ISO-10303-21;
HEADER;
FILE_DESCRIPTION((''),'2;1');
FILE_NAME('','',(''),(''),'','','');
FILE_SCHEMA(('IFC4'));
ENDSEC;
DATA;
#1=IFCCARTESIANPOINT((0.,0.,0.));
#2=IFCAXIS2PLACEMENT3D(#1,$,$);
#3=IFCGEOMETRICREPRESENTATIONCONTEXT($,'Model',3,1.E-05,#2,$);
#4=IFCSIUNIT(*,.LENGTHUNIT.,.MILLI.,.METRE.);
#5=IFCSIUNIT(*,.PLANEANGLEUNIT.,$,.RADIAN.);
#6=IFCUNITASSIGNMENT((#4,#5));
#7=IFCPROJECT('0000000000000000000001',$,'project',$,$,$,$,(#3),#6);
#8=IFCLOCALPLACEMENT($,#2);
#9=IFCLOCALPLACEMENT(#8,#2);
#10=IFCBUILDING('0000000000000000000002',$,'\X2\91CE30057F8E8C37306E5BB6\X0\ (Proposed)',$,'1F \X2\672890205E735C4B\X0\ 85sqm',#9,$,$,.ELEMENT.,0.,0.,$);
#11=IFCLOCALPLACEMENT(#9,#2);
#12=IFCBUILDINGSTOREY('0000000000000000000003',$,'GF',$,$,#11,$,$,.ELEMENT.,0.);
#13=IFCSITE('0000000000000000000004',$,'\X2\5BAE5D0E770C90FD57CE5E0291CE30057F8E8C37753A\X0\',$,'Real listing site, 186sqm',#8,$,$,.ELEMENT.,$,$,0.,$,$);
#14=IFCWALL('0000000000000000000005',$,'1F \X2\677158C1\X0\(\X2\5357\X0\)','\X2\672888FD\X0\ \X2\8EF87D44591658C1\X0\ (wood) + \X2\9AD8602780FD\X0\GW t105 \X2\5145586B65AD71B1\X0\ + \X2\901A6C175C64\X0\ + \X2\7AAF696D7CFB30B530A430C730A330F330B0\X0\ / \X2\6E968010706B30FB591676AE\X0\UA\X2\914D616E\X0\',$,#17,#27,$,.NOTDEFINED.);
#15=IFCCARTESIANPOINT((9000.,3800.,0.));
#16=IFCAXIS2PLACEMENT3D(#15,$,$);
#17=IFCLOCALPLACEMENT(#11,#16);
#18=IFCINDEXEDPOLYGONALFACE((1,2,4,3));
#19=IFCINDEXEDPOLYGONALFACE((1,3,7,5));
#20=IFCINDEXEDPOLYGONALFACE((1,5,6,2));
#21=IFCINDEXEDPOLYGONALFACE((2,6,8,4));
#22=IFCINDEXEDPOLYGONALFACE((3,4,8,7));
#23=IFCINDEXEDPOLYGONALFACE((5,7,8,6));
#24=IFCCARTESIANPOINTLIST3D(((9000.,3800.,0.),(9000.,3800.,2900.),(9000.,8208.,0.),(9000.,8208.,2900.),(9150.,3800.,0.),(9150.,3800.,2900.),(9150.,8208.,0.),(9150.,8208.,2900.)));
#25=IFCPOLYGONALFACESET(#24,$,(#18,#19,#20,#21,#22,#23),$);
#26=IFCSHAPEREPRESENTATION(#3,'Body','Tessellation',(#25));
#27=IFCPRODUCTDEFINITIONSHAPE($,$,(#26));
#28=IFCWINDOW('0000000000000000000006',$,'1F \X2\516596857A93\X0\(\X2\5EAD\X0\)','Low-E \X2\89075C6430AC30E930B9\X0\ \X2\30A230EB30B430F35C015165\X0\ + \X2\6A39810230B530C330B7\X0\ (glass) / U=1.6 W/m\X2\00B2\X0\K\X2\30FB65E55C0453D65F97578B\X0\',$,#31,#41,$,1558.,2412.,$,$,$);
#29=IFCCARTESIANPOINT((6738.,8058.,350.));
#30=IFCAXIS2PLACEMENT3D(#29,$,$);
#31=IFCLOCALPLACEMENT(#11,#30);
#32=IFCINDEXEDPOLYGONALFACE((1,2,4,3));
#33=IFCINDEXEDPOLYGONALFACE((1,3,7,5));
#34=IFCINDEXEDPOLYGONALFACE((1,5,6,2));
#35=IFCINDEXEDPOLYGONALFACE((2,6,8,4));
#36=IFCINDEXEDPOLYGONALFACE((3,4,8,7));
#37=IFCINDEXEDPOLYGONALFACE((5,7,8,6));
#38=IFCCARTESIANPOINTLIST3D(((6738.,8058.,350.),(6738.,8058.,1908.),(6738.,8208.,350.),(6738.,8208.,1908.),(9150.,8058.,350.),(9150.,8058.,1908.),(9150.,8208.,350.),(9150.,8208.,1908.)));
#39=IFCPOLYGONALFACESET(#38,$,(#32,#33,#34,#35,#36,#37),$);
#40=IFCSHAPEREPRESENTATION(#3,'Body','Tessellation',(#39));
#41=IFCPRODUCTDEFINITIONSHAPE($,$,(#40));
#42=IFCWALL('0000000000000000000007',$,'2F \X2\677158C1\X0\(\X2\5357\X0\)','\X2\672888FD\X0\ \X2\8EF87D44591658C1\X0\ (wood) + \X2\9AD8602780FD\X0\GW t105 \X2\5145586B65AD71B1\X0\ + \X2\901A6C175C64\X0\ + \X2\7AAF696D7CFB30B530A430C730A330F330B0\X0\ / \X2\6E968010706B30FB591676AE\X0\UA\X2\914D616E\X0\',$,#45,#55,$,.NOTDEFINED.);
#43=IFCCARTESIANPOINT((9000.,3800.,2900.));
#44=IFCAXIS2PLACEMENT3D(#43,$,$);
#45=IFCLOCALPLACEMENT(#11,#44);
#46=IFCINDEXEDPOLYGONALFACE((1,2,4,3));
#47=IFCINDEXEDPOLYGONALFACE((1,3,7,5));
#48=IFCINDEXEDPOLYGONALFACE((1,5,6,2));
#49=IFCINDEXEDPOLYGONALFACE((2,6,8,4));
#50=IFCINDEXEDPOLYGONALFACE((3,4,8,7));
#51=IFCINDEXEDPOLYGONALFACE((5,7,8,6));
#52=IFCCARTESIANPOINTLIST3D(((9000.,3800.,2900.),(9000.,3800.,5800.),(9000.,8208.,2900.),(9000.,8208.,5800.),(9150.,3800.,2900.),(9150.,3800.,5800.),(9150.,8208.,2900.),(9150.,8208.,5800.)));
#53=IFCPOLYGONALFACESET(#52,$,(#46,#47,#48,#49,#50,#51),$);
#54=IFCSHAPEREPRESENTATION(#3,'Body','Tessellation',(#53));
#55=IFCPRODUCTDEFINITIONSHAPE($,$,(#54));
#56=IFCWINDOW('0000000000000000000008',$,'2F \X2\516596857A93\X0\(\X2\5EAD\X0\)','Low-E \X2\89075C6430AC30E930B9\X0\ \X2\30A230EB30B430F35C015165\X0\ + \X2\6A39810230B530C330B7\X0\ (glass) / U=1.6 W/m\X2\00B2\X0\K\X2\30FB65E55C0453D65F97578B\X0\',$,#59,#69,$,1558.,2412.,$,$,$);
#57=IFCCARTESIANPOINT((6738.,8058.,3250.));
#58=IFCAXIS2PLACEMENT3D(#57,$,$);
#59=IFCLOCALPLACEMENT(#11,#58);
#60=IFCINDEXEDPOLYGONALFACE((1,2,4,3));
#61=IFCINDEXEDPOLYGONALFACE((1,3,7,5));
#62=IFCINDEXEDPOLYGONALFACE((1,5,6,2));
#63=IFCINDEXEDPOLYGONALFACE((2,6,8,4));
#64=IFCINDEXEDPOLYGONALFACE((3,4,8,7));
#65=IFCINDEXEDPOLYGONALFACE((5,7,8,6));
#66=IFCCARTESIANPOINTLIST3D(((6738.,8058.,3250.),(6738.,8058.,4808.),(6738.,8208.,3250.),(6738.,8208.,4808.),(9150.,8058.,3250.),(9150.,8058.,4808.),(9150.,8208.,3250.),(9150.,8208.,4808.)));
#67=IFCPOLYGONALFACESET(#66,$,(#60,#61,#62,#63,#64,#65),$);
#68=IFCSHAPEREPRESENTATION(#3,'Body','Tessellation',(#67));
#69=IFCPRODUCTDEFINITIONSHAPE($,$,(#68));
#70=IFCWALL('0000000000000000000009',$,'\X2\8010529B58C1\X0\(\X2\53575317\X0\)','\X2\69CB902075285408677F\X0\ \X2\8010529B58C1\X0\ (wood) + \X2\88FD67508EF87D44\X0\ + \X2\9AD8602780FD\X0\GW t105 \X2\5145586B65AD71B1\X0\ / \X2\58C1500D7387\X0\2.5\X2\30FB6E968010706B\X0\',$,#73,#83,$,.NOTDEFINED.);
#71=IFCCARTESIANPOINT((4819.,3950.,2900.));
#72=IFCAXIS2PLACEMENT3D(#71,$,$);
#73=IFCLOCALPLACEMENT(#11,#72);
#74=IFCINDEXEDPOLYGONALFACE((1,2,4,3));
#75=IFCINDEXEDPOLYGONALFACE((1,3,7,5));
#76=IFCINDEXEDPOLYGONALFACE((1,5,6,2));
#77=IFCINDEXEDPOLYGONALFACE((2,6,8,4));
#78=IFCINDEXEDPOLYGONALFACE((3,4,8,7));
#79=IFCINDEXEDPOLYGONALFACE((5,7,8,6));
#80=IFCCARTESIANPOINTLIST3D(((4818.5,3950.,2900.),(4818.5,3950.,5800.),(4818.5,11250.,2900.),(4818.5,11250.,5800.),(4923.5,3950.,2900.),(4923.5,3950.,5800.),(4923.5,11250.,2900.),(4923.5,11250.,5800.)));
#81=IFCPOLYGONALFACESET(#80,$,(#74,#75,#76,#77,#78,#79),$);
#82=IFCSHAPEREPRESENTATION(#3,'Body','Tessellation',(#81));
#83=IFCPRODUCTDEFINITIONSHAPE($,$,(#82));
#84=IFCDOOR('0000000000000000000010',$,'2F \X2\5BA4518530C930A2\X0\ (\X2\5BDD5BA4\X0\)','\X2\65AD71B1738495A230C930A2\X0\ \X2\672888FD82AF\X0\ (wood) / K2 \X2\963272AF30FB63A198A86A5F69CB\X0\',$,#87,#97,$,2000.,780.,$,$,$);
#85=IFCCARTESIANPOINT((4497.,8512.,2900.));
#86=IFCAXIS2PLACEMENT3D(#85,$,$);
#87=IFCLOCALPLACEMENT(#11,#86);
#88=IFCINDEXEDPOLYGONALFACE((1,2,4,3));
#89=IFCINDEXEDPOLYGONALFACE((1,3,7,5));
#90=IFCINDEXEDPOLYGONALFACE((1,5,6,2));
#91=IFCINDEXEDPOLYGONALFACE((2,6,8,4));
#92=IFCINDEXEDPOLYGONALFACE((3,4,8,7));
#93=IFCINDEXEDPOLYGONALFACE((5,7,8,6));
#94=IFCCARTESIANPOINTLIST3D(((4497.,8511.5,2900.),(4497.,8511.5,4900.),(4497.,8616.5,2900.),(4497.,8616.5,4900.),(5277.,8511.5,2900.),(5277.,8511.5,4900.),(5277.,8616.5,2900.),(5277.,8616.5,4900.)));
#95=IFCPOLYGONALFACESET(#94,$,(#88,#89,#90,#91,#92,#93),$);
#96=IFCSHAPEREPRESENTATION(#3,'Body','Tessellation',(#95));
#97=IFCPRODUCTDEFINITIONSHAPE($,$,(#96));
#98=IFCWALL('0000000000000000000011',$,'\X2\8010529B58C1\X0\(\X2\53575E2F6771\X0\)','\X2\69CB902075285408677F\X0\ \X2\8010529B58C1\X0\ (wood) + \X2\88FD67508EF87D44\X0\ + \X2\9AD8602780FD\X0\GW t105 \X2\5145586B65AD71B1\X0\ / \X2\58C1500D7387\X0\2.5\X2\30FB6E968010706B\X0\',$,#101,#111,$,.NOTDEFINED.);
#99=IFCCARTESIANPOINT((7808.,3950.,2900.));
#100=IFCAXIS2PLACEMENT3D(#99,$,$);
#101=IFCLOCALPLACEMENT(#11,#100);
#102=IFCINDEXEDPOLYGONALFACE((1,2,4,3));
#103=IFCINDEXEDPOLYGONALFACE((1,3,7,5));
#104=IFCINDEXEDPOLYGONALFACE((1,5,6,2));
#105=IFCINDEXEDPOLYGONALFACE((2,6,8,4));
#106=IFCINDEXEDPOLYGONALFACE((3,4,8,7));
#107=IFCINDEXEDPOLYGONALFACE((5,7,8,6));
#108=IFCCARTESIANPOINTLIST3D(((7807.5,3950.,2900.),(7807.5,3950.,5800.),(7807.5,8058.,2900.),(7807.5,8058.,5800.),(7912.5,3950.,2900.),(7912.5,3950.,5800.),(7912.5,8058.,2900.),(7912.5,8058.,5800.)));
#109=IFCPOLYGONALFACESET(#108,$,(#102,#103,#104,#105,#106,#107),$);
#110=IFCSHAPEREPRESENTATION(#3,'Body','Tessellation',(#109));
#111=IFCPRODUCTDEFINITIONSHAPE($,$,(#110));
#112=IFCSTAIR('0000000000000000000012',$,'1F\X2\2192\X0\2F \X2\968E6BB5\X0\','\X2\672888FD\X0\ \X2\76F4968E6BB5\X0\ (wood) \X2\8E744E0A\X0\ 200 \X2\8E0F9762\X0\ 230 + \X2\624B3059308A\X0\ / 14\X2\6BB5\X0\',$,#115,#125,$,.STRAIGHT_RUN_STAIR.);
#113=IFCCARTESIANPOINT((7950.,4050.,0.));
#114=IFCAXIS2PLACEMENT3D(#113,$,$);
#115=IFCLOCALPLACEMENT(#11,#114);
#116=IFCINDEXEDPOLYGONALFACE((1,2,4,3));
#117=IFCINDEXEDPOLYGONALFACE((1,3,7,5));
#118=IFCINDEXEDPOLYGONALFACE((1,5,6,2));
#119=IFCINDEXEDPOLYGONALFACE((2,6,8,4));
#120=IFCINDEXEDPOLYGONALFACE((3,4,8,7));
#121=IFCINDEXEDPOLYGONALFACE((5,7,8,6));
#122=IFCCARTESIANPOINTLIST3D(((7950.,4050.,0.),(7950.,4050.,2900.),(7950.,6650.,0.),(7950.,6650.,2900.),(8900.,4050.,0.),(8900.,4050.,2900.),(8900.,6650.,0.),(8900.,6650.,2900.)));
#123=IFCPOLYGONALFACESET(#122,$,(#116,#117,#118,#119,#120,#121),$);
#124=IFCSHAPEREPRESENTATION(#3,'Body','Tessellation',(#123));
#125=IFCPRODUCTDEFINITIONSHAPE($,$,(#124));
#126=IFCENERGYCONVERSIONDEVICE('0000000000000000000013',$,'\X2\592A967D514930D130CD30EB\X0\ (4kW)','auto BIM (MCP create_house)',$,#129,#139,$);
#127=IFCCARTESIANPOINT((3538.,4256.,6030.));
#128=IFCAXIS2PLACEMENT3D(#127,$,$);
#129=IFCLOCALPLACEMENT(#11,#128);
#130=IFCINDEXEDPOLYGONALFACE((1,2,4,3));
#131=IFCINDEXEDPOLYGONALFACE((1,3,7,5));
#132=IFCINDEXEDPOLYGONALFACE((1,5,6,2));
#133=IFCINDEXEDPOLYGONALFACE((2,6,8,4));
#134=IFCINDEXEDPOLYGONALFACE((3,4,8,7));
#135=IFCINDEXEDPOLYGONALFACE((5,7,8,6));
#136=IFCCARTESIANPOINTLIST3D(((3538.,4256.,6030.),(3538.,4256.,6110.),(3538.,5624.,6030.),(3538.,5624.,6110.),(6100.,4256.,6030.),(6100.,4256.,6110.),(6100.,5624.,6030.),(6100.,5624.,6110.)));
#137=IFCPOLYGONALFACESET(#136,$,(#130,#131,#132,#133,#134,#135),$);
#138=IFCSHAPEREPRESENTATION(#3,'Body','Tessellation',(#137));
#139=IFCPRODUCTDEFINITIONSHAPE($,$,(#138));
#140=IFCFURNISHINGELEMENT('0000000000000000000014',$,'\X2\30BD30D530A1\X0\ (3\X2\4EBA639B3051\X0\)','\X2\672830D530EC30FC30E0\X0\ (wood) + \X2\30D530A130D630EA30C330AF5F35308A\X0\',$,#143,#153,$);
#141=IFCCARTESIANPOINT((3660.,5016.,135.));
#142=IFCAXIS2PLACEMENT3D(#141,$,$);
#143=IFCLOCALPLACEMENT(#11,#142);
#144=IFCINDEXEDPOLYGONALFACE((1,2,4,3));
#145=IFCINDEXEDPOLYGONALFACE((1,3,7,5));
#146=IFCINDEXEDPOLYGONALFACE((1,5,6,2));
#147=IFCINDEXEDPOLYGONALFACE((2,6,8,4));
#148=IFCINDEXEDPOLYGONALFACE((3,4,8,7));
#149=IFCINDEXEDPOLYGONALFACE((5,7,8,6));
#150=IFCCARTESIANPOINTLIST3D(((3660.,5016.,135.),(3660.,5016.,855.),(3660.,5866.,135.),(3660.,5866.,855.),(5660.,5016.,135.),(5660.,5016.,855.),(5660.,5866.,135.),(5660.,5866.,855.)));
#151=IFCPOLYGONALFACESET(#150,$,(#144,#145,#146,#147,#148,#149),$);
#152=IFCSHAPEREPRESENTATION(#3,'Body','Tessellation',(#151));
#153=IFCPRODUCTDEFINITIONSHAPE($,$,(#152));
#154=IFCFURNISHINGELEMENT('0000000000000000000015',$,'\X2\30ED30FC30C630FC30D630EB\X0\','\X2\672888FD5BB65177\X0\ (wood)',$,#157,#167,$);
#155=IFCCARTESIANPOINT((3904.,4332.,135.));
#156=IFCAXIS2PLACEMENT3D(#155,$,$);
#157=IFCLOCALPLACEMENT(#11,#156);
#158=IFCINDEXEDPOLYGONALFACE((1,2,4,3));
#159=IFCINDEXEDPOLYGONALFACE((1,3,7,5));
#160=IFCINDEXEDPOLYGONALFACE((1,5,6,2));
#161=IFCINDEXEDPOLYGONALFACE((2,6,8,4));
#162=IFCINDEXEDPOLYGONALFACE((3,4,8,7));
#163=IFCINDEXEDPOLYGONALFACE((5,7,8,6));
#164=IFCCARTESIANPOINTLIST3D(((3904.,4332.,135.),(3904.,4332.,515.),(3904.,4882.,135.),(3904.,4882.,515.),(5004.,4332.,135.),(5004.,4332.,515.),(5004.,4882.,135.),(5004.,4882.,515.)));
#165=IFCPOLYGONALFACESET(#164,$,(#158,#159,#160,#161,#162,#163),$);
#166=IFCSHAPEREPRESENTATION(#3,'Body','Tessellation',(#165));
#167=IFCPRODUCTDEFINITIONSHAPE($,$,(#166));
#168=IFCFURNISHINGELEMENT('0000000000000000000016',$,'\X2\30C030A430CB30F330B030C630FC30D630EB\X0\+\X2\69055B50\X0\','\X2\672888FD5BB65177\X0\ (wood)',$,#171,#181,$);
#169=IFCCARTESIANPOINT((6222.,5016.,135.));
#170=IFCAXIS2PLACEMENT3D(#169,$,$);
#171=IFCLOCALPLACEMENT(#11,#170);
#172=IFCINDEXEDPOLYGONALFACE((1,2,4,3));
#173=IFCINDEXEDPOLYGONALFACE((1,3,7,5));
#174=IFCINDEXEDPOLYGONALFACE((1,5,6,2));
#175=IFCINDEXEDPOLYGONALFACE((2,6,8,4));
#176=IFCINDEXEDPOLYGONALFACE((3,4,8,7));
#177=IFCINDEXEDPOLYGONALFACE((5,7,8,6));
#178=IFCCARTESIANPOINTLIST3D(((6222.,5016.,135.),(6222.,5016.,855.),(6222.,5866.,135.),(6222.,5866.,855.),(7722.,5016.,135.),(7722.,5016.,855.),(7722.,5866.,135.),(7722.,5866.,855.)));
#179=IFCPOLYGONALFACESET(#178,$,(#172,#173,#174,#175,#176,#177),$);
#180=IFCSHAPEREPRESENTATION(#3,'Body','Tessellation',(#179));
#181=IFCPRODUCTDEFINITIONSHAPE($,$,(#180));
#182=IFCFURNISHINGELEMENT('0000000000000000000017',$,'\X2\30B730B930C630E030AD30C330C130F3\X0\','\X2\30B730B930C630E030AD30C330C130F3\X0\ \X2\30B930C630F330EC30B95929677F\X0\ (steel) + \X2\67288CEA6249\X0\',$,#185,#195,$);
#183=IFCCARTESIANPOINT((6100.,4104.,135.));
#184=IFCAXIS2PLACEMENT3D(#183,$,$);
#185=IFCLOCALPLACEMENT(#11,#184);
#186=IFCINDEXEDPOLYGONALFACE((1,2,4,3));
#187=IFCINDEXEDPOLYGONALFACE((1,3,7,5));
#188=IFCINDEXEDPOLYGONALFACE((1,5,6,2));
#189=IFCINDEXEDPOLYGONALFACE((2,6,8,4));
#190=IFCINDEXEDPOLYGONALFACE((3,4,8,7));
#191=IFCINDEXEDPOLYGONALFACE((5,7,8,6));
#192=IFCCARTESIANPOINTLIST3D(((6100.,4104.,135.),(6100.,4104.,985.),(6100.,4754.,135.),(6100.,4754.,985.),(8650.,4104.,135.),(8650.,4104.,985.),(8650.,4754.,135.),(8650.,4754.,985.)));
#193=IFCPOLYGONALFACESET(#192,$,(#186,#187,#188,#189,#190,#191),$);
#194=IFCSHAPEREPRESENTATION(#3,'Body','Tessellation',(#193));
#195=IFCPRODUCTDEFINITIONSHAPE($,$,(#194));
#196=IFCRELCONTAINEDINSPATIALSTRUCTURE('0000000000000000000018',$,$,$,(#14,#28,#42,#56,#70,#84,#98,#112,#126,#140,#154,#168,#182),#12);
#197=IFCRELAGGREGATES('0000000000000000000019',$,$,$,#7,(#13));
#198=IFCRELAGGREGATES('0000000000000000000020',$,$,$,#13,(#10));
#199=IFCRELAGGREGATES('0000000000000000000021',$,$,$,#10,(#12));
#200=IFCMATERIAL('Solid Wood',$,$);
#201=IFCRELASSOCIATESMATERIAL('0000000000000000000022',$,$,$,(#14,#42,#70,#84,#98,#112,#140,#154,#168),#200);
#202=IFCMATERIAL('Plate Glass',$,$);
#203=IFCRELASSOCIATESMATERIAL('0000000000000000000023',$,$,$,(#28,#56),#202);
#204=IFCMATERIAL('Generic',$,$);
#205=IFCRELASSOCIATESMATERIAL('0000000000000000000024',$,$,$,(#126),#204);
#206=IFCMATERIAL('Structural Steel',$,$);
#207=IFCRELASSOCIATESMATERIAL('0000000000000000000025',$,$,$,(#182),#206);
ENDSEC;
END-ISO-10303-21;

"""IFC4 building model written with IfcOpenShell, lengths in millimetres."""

from ifc_helpers import new_model, si_unit, frame, frame_2d, origin, place, context, project, spatial, rectangle, extrude, material, element, fill, save


model = new_model("IFC4")

# Units and contexts
model_context = context("Model", 3, precision=1e-05, world=origin())
ifc_project = project(units=[si_unit("LENGTHUNIT", "METRE", prefix="MILLI"), si_unit("PLANEANGLEUNIT", "RADIAN")], contexts=[model_context])

# Site, building, storey
site_placement = place(None, origin())
site = spatial("IfcSite", under=ifc_project, at=site_placement, Name="宮崎県都城市野々美谷町", ObjectType="Real listing site, 186sqm", CompositionType="ELEMENT", RefElevation=0.0)
building_placement = place(site_placement, origin())
building = spatial("IfcBuilding", under=site, at=building_placement, Name="野々美谷の家 (Proposed)", ObjectType="1F 木造平屋 85sqm", CompositionType="ELEMENT", ElevationOfRefHeight=0.0, ElevationOfTerrain=0.0)
storey_placement = place(building_placement, origin())
storey = spatial("IfcBuildingStorey", under=building, at=storey_placement, Name="GF", CompositionType="ELEMENT", Elevation=0.0)

# Wall, opening, window
ifc_material_1 = material(Name="Solid Wood")
wall_1_placement = place(storey_placement, frame((9000.0, 3800.0, 0.0)))
wall_1 = element("IfcWall", 1, at=wall_1_placement, inside=storey, material=ifc_material_1, Name="1F 東壁(南)", Description="木製 軸組外壁 (wood) + 高性能GW t105 充填断熱 + 通気層 + 窯業系サイディング / 準耐火・外皮UA配慮", PredefinedType="NOTDEFINED", context=model_context, shape_type="SweptSolid", body=[
    extrude(rectangle(XDim=150.0, YDim=4408.0, at=frame_2d((75.0, 2204.0))), frame((9000.0, 3800.0, 0.0)), (0.0, 0.0, 1.0), 2900.0),
])
opening_1_placement = place(storey_placement, frame((6738.0, 8058.0, 350.0)))
opening_1 = element("IfcOpeningElement", 2, at=opening_1_placement, cuts=wall_1, PredefinedType="NOTDEFINED", context=model_context, shape_type="SweptSolid", body=[
    extrude(rectangle(XDim=2412.0, YDim=150.0, at=frame_2d((1206.0, 75.0))), frame((6738.0, 8058.0, 350.0)), (0.0, 0.0, 1.0), 1558.0),
])
ifc_material_2 = material(Name="Plate Glass")
window_1_placement = place(storey_placement, frame((6738.0, 8058.0, 350.0)))
window_1 = element("IfcWindow", 3, at=window_1_placement, inside=storey, material=ifc_material_2, Name="1F 入隅窓(庭)", Description="Low-E 複層ガラス アルゴン封入 + 樹脂サッシ (glass) / U=1.6 W/m²K・日射取得型", OverallHeight=1558.0, OverallWidth=2412.0, context=model_context, shape_type="SweptSolid", body=[
    extrude(rectangle(XDim=2412.0, YDim=150.0, at=frame_2d((1206.0, 75.0))), frame((6738.0, 8058.0, 350.0)), (0.0, 0.0, 1.0), 1558.0),
])
fill(opening_1, window_1)

# Wall, opening, window
wall_2_placement = place(storey_placement, frame((9000.0, 3800.0, 2900.0)))
wall_2 = element("IfcWall", 4, at=wall_2_placement, inside=storey, material=ifc_material_1, Name="2F 東壁(南)", Description="木製 軸組外壁 (wood) + 高性能GW t105 充填断熱 + 通気層 + 窯業系サイディング / 準耐火・外皮UA配慮", PredefinedType="NOTDEFINED", context=model_context, shape_type="SweptSolid", body=[
    extrude(rectangle(XDim=150.0, YDim=4408.0, at=frame_2d((75.0, 2204.0))), frame((9000.0, 3800.0, 2900.0)), (0.0, 0.0, 1.0), 2900.0),
])
opening_2_placement = place(storey_placement, frame((6738.0, 8058.0, 3250.0)))
opening_2 = element("IfcOpeningElement", 5, at=opening_2_placement, cuts=wall_2, PredefinedType="NOTDEFINED", context=model_context, shape_type="SweptSolid", body=[
    extrude(rectangle(XDim=2412.0, YDim=150.0, at=frame_2d((1206.0, 75.0))), frame((6738.0, 8058.0, 3250.0)), (0.0, 0.0, 1.0), 1558.0),
])
window_2_placement = place(storey_placement, frame((6738.0, 8058.0, 3250.0)))
window_2 = element("IfcWindow", 6, at=window_2_placement, inside=storey, material=ifc_material_2, Name="2F 入隅窓(庭)", Description="Low-E 複層ガラス アルゴン封入 + 樹脂サッシ (glass) / U=1.6 W/m²K・日射取得型", OverallHeight=1558.0, OverallWidth=2412.0, context=model_context, shape_type="SweptSolid", body=[
    extrude(rectangle(XDim=2412.0, YDim=150.0, at=frame_2d((1206.0, 75.0))), frame((6738.0, 8058.0, 3250.0)), (0.0, 0.0, 1.0), 1558.0),
])
fill(opening_2, window_2)

# Wall, opening, door
wall_3_placement = place(storey_placement, frame((4819.0, 3950.0, 2900.0)))
wall_3 = element("IfcWall", 7, at=wall_3_placement, inside=storey, material=ifc_material_1, Name="耐力壁(南北)", Description="構造用合板 耐力壁 (wood) + 製材軸組 + 高性能GW t105 充填断熱 / 壁倍率2.5・準耐火", PredefinedType="NOTDEFINED", context=model_context, shape_type="SweptSolid", body=[
    extrude(rectangle(XDim=105.0, YDim=7300.0, at=frame_2d((52.0, 3650.0))), frame((4819.0, 3950.0, 2900.0)), (0.0, 0.0, 1.0), 2900.0),
])
opening_3_placement = place(storey_placement, frame((4497.0, 8512.0, 2900.0)))
opening_3 = element("IfcOpeningElement", 8, at=opening_3_placement, cuts=wall_3, PredefinedType="NOTDEFINED", context=model_context, shape_type="SweptSolid", body=[
    extrude(rectangle(XDim=780.0, YDim=105.0, at=frame_2d((390.0, 52.0))), frame((4497.0, 8512.0, 2900.0)), (0.0, 0.0, 1.0), 2000.0),
])
door_1_placement = place(storey_placement, frame((4497.0, 8512.0, 2900.0)))
door_1 = element("IfcDoor", 9, at=door_1_placement, inside=storey, material=ifc_material_1, Name="2F 室内ドア (寝室)", Description="断熱玄関ドア 木製芯 (wood) / K2 防犯・採風機構", OverallHeight=2000.0, OverallWidth=780.0, context=model_context, shape_type="SweptSolid", body=[
    extrude(rectangle(XDim=780.0, YDim=105.0, at=frame_2d((390.0, 52.0))), frame((4497.0, 8512.0, 2900.0)), (0.0, 0.0, 1.0), 2000.0),
])
fill(opening_3, door_1)

# Wall
wall_4_placement = place(storey_placement, frame((7808.0, 3950.0, 2900.0)))
element("IfcWall", 10, at=wall_4_placement, inside=storey, material=ifc_material_1, Name="耐力壁(南帯東)", Description="構造用合板 耐力壁 (wood) + 製材軸組 + 高性能GW t105 充填断熱 / 壁倍率2.5・準耐火", PredefinedType="NOTDEFINED", context=model_context, shape_type="SweptSolid", body=[
    extrude(rectangle(XDim=105.0, YDim=4108.0, at=frame_2d((52.0, 2054.0))), frame((7808.0, 3950.0, 2900.0)), (0.0, 0.0, 1.0), 2900.0),
])

# Stair
stair_placement = place(storey_placement, frame((7950.0, 4050.0, 0.0)))
element("IfcStair", 11, at=stair_placement, inside=storey, material=ifc_material_1, Name="1F→2F 階段", Description="木製 直階段 (wood) 蹴上 200 踏面 230 + 手すり / 14段", PredefinedType="STRAIGHT_RUN_STAIR", context=model_context, shape_type="SweptSolid", body=[
    extrude(rectangle(XDim=950.0, YDim=2600.0, at=frame_2d((475.0, 1300.0))), frame((7950.0, 4050.0, 0.0)), (0.0, 0.0, 1.0), 2900.0),
])

# Energy conversion device
ifc_material_3 = material(Name="Generic")
energy_conversion_device_placement = place(storey_placement, frame((3538.0, 4256.0, 6030.0)))
element("IfcEnergyConversionDevice", 12, at=energy_conversion_device_placement, inside=storey, material=ifc_material_3, Name="太陽光パネル (4kW)", Description="auto BIM (MCP create_house)", context=model_context, shape_type="SweptSolid", body=[
    extrude(rectangle(XDim=2562.0, YDim=1368.0, at=frame_2d((1281.0, 684.0))), frame((3538.0, 4256.0, 6030.0)), (0.0, 0.0, 1.0), 80.0),
])

# Furnishing elements
furnishing_1_placement = place(storey_placement, frame((3660.0, 5016.0, 135.0)))
element("IfcFurnishingElement", 13, at=furnishing_1_placement, inside=storey, material=ifc_material_1, Name="ソファ (3人掛け)", Description="木フレーム (wood) + ファブリック張り", context=model_context, shape_type="SweptSolid", body=[
    extrude(rectangle(XDim=2000.0, YDim=850.0, at=frame_2d((1000.0, 425.0))), frame((3660.0, 5016.0, 135.0)), (0.0, 0.0, 1.0), 720.0),
])
furnishing_2_placement = place(storey_placement, frame((3904.0, 4332.0, 135.0)))
element("IfcFurnishingElement", 14, at=furnishing_2_placement, inside=storey, material=ifc_material_1, Name="ローテーブル", Description="木製家具 (wood)", context=model_context, shape_type="SweptSolid", body=[
    extrude(rectangle(XDim=1100.0, YDim=550.0, at=frame_2d((550.0, 275.0))), frame((3904.0, 4332.0, 135.0)), (0.0, 0.0, 1.0), 380.0),
])
furnishing_3_placement = place(storey_placement, frame((6222.0, 5016.0, 135.0)))
element("IfcFurnishingElement", 15, at=furnishing_3_placement, inside=storey, material=ifc_material_1, Name="ダイニングテーブル+椅子", Description="木製家具 (wood)", context=model_context, shape_type="SweptSolid", body=[
    extrude(rectangle(XDim=1500.0, YDim=850.0, at=frame_2d((750.0, 425.0))), frame((6222.0, 5016.0, 135.0)), (0.0, 0.0, 1.0), 720.0),
])
ifc_material_4 = material(Name="Structural Steel")
furnishing_4_placement = place(storey_placement, frame((6100.0, 4104.0, 135.0)))
element("IfcFurnishingElement", 16, at=furnishing_4_placement, inside=storey, material=ifc_material_4, Name="システムキッチン", Description="システムキッチン ステンレス天板 (steel) + 木質扉", context=model_context, shape_type="SweptSolid", body=[
    extrude(rectangle(XDim=2550.0, YDim=650.0, at=frame_2d((1275.0, 325.0))), frame((6100.0, 4104.0, 135.0)), (0.0, 0.0, 1.0), 850.0),
])

save(model, "model.ifc")
